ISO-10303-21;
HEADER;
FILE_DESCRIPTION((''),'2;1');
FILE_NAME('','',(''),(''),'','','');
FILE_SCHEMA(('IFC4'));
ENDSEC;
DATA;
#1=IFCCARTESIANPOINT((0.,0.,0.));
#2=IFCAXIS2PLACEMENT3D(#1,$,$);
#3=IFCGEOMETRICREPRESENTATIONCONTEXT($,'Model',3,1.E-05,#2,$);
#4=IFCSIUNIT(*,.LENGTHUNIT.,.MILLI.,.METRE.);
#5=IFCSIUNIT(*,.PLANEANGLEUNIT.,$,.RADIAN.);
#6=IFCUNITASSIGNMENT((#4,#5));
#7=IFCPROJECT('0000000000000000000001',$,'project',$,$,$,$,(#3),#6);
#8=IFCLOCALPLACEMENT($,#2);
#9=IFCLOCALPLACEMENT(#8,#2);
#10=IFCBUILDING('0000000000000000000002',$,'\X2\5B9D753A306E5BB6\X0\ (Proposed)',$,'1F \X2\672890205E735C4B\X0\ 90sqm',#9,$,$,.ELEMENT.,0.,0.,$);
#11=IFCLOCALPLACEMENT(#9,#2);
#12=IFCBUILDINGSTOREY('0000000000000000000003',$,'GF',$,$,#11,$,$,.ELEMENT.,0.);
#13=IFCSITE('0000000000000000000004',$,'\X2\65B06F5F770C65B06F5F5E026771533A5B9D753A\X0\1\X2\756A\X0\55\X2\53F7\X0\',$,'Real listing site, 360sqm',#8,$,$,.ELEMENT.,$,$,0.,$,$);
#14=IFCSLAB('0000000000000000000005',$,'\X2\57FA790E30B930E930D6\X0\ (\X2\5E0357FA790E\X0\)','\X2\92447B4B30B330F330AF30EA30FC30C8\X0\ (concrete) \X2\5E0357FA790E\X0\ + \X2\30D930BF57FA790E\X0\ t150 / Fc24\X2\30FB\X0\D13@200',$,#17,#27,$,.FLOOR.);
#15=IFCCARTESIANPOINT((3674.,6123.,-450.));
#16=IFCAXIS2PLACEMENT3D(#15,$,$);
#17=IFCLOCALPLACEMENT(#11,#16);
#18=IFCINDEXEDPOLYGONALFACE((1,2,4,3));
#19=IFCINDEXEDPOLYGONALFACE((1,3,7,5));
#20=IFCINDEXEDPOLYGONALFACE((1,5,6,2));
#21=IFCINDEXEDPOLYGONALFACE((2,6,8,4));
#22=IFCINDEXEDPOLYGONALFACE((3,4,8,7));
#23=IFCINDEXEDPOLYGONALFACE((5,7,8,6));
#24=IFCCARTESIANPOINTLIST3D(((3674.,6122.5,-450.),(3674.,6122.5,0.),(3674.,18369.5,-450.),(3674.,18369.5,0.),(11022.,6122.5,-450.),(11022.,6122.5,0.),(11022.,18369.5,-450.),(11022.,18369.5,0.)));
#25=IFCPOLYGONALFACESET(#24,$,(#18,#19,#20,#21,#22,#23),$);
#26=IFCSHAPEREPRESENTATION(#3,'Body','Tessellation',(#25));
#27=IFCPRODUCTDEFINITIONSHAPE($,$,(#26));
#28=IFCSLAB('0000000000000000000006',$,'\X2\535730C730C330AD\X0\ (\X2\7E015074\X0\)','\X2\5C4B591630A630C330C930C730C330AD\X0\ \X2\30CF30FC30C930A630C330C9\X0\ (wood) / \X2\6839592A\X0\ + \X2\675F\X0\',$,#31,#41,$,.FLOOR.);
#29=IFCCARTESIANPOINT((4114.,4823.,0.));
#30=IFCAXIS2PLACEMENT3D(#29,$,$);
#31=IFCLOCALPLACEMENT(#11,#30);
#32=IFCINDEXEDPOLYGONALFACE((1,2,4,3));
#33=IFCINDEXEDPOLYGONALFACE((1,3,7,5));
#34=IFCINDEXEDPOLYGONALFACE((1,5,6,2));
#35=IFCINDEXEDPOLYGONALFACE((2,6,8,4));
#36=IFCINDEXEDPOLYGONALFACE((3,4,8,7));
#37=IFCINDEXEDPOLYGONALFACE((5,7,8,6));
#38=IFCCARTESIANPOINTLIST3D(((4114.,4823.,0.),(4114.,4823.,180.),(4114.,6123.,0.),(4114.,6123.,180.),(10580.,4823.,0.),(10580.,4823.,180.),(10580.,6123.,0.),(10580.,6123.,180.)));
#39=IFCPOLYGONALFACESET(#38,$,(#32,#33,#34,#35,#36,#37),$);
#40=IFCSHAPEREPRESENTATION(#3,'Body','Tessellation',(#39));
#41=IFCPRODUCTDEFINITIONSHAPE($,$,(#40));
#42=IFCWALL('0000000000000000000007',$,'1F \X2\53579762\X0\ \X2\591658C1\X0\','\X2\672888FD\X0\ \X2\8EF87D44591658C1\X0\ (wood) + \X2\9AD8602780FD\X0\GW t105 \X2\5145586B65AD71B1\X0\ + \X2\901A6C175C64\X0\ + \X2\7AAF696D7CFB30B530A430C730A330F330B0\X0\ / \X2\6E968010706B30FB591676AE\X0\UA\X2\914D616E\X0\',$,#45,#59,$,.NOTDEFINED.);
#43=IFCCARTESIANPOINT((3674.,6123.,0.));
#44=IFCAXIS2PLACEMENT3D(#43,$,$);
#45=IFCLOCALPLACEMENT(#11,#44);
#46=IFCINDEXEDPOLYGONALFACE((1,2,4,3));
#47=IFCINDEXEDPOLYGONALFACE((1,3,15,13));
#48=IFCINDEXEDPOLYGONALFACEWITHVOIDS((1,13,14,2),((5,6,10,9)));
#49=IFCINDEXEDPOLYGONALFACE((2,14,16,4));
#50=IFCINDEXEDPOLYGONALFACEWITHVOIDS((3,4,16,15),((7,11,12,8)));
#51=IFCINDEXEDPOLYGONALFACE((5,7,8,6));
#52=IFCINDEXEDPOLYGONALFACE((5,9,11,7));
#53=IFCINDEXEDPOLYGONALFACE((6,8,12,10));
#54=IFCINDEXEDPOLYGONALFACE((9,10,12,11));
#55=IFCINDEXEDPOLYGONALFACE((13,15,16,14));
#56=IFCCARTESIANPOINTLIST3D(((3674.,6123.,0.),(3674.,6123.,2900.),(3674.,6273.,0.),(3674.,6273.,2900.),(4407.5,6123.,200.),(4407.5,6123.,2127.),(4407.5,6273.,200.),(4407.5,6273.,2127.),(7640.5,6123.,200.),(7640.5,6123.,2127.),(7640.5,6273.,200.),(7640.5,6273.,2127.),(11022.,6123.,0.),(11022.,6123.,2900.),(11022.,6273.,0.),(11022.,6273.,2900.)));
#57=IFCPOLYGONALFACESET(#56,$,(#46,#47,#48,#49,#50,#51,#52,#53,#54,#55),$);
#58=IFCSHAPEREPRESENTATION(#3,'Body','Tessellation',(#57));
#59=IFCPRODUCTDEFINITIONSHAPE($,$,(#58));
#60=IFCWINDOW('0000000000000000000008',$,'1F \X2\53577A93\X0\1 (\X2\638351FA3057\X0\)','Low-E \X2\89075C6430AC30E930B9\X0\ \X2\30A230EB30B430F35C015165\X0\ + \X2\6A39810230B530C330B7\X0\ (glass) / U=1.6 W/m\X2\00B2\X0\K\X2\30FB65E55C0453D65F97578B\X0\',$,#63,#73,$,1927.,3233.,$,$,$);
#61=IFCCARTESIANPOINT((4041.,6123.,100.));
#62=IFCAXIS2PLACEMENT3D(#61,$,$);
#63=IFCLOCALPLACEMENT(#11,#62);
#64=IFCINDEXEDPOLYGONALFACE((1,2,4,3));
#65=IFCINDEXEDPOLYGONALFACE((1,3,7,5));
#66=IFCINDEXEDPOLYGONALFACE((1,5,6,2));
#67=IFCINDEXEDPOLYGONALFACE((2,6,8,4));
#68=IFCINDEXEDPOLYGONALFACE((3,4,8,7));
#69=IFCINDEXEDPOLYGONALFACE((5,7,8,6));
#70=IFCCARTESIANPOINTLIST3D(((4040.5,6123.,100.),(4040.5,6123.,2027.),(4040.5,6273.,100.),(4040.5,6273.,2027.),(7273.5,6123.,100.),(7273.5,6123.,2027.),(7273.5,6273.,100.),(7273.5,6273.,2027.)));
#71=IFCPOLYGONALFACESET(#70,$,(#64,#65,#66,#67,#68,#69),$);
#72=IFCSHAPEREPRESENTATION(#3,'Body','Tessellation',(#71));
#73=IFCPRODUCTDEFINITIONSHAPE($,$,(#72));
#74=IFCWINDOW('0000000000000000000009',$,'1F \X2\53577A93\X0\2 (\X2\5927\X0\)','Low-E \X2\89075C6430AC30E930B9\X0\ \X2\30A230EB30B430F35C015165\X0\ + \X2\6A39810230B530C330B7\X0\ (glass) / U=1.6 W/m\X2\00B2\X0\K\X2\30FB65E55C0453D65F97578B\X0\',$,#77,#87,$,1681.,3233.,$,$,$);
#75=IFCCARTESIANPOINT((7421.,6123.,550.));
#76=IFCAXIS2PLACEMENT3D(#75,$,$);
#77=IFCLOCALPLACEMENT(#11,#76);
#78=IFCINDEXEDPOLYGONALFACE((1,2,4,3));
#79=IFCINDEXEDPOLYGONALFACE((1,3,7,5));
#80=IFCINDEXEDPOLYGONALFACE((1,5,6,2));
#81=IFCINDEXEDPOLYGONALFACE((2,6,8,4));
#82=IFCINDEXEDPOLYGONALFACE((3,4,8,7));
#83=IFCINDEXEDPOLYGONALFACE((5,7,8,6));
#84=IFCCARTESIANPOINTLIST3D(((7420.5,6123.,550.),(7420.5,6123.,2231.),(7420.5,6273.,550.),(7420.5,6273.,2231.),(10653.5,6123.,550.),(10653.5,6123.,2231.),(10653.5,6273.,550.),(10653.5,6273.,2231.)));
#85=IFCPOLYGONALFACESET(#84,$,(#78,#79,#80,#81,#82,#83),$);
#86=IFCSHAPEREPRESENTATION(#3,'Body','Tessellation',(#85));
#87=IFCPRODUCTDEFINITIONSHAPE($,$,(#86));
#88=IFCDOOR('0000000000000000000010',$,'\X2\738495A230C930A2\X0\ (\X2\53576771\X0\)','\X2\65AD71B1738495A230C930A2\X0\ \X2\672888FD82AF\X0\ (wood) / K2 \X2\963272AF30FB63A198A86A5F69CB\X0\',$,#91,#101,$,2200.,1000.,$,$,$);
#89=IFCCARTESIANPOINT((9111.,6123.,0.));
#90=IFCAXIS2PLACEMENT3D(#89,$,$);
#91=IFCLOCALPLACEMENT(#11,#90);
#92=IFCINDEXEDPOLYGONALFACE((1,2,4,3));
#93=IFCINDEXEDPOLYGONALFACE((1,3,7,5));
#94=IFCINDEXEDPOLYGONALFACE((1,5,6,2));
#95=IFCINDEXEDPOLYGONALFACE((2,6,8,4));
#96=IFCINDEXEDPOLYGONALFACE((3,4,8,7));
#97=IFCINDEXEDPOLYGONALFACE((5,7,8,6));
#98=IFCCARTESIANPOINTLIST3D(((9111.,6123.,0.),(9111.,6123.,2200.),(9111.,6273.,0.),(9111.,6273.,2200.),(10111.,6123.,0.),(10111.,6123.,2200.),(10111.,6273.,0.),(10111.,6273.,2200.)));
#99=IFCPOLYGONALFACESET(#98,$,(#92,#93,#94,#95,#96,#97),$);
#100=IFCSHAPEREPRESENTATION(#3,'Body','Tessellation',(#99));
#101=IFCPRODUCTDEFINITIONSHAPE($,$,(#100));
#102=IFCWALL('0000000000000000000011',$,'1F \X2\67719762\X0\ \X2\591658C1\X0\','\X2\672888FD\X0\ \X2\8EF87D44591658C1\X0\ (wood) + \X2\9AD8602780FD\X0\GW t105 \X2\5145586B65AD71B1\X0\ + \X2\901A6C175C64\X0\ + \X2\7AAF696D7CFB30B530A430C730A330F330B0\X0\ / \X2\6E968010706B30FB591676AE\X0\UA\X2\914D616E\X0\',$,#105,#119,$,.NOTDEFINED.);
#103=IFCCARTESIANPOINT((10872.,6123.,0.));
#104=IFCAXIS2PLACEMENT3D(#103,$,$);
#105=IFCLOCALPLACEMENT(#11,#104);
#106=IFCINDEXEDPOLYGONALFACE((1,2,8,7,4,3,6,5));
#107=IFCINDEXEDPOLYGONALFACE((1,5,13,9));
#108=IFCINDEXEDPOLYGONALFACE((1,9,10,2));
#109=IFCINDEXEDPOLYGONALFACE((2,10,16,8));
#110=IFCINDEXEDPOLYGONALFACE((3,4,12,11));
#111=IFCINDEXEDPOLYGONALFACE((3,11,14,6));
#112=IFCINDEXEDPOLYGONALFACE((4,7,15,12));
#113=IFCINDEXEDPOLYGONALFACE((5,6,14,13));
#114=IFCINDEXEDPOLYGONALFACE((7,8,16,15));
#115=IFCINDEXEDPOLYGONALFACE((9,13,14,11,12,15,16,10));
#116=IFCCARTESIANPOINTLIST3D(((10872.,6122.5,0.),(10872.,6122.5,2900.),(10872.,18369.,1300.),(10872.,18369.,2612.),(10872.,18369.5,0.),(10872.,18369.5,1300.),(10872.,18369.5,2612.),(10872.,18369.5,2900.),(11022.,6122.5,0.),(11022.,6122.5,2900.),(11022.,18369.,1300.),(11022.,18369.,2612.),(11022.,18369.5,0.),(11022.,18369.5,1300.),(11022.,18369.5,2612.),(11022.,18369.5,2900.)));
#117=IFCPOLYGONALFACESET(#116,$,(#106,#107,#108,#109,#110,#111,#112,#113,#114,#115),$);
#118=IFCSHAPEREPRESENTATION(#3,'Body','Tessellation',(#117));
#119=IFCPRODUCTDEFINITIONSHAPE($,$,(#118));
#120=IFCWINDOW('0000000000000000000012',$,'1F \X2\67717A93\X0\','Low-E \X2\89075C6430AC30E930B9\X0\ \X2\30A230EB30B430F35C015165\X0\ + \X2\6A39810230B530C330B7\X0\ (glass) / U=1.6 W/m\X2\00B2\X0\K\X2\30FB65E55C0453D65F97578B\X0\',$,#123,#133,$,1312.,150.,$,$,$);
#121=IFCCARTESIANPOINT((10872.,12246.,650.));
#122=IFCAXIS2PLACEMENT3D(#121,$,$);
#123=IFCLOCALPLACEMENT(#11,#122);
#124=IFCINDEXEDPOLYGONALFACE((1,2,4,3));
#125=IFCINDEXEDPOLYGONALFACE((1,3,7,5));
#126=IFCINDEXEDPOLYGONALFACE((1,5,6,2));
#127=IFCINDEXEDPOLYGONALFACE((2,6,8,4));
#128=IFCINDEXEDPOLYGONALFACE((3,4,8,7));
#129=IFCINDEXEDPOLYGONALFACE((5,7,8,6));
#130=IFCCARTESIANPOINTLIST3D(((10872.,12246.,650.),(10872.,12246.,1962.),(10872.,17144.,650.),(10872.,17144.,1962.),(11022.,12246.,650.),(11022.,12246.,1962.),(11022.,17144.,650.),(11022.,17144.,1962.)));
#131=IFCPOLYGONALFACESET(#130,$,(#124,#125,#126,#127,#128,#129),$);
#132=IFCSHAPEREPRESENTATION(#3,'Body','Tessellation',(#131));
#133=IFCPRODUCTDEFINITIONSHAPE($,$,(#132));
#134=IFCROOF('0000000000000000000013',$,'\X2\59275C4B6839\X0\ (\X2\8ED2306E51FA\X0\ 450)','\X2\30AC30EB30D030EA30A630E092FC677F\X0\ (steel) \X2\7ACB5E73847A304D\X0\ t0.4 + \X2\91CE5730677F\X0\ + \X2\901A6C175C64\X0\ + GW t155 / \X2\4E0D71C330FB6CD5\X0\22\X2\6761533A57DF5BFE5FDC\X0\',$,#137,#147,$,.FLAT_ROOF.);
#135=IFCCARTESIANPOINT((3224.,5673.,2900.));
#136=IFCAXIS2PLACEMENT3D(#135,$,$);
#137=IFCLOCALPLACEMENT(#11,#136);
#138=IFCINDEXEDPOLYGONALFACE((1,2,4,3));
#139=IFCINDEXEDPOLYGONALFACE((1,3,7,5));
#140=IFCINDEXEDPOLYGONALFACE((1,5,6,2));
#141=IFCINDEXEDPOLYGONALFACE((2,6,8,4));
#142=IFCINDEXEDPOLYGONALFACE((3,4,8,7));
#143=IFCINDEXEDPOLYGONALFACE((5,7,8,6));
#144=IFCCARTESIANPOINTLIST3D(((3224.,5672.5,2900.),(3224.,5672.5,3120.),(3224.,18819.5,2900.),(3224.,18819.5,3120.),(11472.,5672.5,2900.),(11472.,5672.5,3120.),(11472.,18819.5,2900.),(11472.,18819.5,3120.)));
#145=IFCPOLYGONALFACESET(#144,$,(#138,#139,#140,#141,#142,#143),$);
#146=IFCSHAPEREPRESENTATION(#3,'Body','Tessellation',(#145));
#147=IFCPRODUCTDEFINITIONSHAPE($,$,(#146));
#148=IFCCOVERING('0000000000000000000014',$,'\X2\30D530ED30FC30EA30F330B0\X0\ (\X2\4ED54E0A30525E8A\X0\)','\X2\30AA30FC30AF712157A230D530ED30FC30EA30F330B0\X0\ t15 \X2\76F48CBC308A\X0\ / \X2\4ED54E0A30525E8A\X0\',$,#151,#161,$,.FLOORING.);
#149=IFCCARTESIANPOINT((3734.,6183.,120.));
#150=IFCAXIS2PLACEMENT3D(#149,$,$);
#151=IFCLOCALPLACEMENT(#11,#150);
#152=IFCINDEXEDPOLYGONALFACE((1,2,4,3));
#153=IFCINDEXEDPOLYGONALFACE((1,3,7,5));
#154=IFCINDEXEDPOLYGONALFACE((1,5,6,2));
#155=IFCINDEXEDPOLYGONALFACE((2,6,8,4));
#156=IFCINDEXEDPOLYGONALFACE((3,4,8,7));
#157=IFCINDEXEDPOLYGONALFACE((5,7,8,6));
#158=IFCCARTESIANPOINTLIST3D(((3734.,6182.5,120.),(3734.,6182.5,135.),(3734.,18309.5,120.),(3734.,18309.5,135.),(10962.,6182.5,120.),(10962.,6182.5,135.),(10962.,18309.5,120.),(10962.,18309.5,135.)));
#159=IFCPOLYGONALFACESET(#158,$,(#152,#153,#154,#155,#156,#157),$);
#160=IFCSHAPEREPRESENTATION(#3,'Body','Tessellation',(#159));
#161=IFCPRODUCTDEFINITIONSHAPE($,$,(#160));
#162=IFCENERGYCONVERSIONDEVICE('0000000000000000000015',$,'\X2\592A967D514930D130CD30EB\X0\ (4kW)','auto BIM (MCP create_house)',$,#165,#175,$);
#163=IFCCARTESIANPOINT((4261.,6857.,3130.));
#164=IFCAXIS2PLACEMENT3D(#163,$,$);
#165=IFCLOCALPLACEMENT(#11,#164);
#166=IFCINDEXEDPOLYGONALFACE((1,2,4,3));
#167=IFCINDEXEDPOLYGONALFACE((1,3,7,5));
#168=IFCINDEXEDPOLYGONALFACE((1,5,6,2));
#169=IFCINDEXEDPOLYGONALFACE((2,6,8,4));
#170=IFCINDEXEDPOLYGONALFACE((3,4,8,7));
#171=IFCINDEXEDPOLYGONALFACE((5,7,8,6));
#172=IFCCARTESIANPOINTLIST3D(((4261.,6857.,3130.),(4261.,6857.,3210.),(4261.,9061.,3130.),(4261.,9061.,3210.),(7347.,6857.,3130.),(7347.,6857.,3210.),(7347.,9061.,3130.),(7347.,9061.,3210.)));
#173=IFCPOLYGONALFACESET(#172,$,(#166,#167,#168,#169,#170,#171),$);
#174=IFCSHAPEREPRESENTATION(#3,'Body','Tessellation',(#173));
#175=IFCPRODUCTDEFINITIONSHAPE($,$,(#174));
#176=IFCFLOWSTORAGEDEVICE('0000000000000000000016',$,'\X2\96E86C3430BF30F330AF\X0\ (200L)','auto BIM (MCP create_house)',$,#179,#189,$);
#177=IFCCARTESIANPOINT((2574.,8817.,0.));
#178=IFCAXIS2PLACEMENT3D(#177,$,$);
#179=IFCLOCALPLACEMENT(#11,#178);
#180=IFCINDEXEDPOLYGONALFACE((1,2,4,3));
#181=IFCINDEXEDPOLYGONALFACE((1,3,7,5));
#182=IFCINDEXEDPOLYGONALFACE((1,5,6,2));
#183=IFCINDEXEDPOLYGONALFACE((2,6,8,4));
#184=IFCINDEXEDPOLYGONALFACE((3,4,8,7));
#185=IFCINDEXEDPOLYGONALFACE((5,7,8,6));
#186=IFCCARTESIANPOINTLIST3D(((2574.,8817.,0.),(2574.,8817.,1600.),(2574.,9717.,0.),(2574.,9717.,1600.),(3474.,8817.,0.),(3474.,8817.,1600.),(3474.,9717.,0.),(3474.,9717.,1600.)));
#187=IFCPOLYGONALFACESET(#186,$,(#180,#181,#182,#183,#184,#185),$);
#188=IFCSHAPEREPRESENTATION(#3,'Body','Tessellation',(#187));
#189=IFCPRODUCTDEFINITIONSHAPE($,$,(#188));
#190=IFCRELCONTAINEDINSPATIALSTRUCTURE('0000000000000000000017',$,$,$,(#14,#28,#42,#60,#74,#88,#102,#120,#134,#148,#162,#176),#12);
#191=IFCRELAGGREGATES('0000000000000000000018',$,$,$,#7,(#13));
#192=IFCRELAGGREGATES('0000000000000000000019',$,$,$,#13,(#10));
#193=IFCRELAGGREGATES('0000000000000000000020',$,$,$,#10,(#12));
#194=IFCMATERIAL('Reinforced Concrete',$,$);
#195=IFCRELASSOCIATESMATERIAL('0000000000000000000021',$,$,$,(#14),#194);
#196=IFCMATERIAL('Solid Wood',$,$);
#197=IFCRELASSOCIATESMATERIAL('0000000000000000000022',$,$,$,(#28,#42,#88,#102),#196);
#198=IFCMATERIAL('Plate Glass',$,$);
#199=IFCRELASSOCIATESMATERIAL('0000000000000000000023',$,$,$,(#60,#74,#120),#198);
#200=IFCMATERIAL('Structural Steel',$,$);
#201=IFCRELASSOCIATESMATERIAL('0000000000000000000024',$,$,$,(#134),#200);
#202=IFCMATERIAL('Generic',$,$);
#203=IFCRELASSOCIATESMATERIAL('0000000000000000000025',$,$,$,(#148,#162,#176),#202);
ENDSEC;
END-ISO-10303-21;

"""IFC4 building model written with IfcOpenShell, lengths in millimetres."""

from ifc_helpers import new_model, si_unit, frame, frame_2d, origin, place, context, project, spatial, rectangle, extrude, material, element, fill, save


model = new_model("IFC4")

# Units and contexts
model_context = context("Model", 3, precision=1e-05, world=origin())
ifc_project = project(units=[si_unit("LENGTHUNIT", "METRE", prefix="MILLI"), si_unit("PLANEANGLEUNIT", "RADIAN")], contexts=[model_context])

# Site, building, storey
site_placement = place(None, origin())
site = spatial("IfcSite", under=ifc_project, at=site_placement, Name="新潟県新潟市東区宝町1番55号", ObjectType="Real listing site, 360sqm", CompositionType="ELEMENT", RefElevation=0.0)
building_placement = place(site_placement, origin())
building = spatial("IfcBuilding", under=site, at=building_placement, Name="宝町の家 (Proposed)", ObjectType="1F 木造平屋 90sqm", CompositionType="ELEMENT", ElevationOfRefHeight=0.0, ElevationOfTerrain=0.0)
storey_placement = place(building_placement, origin())
storey = spatial("IfcBuildingStorey", under=building, at=storey_placement, Name="GF", CompositionType="ELEMENT", Elevation=0.0)

# Slabs
ifc_material_1 = material(Name="Reinforced Concrete")
slab_1_placement = place(storey_placement, frame((3674.0, 6123.0, -450.0)))
element("IfcSlab", 1, at=slab_1_placement, inside=storey, material=ifc_material_1, Name="基礎スラブ (布基礎)", Description="鉄筋コンクリート (concrete) 布基礎 + ベタ基礎 t150 / Fc24・D13@200", PredefinedType="FLOOR", context=model_context, shape_type="SweptSolid", body=[
    extrude(rectangle(XDim=7348.0, YDim=12247.0, at=frame_2d((3674.0, 6123.0))), frame((3674.0, 6123.0, -450.0)), (0.0, 0.0, 1.0), 450.0),
])
ifc_material_2 = material(Name="Solid Wood")
slab_2_placement = place(storey_placement, frame((4114.0, 4823.0, 0.0)))
element("IfcSlab", 2, at=slab_2_placement, inside=storey, material=ifc_material_2, Name="南デッキ (縁側)", Description="屋外ウッドデッキ ハードウッド (wood) / 根太 + 束", PredefinedType="FLOOR", context=model_context, shape_type="SweptSolid", body=[
    extrude(rectangle(XDim=6466.0, YDim=1300.0, at=frame_2d((3233.0, 650.0))), frame((4114.0, 4823.0, 0.0)), (0.0, 0.0, 1.0), 180.0),
])

# Wall, openings, windows, door
wall_1_placement = place(storey_placement, frame((3674.0, 6123.0, 0.0)))
wall_1 = element("IfcWall", 3, at=wall_1_placement, inside=storey, material=ifc_material_2, Name="1F 南面 外壁", Description="木製 軸組外壁 (wood) + 高性能GW t105 充填断熱 + 通気層 + 窯業系サイディング / 準耐火・外皮UA配慮", PredefinedType="NOTDEFINED", context=model_context, shape_type="SweptSolid", body=[
    extrude(rectangle(XDim=7348.0, YDim=150.0, at=frame_2d((3674.0, 75.0))), frame((3674.0, 6123.0, 0.0)), (0.0, 0.0, 1.0), 2900.0),
])
opening_1_placement = place(storey_placement, frame((4041.0, 6123.0, 100.0)))
opening_1 = element("IfcOpeningElement", 4, at=opening_1_placement, cuts=wall_1, PredefinedType="NOTDEFINED", context=model_context, shape_type="SweptSolid", body=[
    extrude(rectangle(XDim=3233.0, YDim=150.0, at=frame_2d((1616.0, 75.0))), frame((4041.0, 6123.0, 100.0)), (0.0, 0.0, 1.0), 1927.0),
])
opening_2_placement = place(storey_placement, frame((7421.0, 6123.0, 550.0)))
opening_2 = element("IfcOpeningElement", 5, at=opening_2_placement, cuts=wall_1, PredefinedType="NOTDEFINED", context=model_context, shape_type="SweptSolid", body=[
    extrude(rectangle(XDim=3233.0, YDim=150.0, at=frame_2d((1616.0, 75.0))), frame((7421.0, 6123.0, 550.0)), (0.0, 0.0, 1.0), 1681.0),
])
opening_3_placement = place(storey_placement, frame((9111.0, 6123.0, 0.0)))
opening_3 = element("IfcOpeningElement", 6, at=opening_3_placement, cuts=wall_1, PredefinedType="NOTDEFINED", context=model_context, shape_type="SweptSolid", body=[
    extrude(rectangle(XDim=1000.0, YDim=150.0, at=frame_2d((500.0, 75.0))), frame((9111.0, 6123.0, 0.0)), (0.0, 0.0, 1.0), 2200.0),
])
ifc_material_3 = material(Name="Plate Glass")
window_1_placement = place(storey_placement, frame((4041.0, 6123.0, 100.0)))
window_1 = element("IfcWindow", 7, at=window_1_placement, inside=storey, material=ifc_material_3, Name="1F 南窓1 (掃出し)", Description="Low-E 複層ガラス アルゴン封入 + 樹脂サッシ (glass) / U=1.6 W/m²K・日射取得型", OverallHeight=1927.0, OverallWidth=3233.0, context=model_context, shape_type="SweptSolid", body=[
    extrude(rectangle(XDim=3233.0, YDim=150.0, at=frame_2d((1616.0, 75.0))), frame((4041.0, 6123.0, 100.0)), (0.0, 0.0, 1.0), 1927.0),
])
fill(opening_1, window_1)
window_2_placement = place(storey_placement, frame((7421.0, 6123.0, 550.0)))
window_2 = element("IfcWindow", 8, at=window_2_placement, inside=storey, material=ifc_material_3, Name="1F 南窓2 (大)", Description="Low-E 複層ガラス アルゴン封入 + 樹脂サッシ (glass) / U=1.6 W/m²K・日射取得型", OverallHeight=1681.0, OverallWidth=3233.0, context=model_context, shape_type="SweptSolid", body=[
    extrude(rectangle(XDim=3233.0, YDim=150.0, at=frame_2d((1616.0, 75.0))), frame((7421.0, 6123.0, 550.0)), (0.0, 0.0, 1.0), 1681.0),
])
fill(opening_2, window_2)
door_placement = place(storey_placement, frame((9111.0, 6123.0, 0.0)))
door = element("IfcDoor", 9, at=door_placement, inside=storey, material=ifc_material_2, Name="玄関ドア (南東)", Description="断熱玄関ドア 木製芯 (wood) / K2 防犯・採風機構", OverallHeight=2200.0, OverallWidth=1000.0, context=model_context, shape_type="SweptSolid", body=[
    extrude(rectangle(XDim=1000.0, YDim=150.0, at=frame_2d((500.0, 75.0))), frame((9111.0, 6123.0, 0.0)), (0.0, 0.0, 1.0), 2200.0),
])
fill(opening_3, door)

# Wall, opening, window
wall_2_placement = place(storey_placement, frame((10872.0, 6123.0, 0.0)))
wall_2 = element("IfcWall", 10, at=wall_2_placement, inside=storey, material=ifc_material_2, Name="1F 東面 外壁", Description="木製 軸組外壁 (wood) + 高性能GW t105 充填断熱 + 通気層 + 窯業系サイディング / 準耐火・外皮UA配慮", PredefinedType="NOTDEFINED", context=model_context, shape_type="SweptSolid", body=[
    extrude(rectangle(XDim=150.0, YDim=12247.0, at=frame_2d((75.0, 6123.0))), frame((10872.0, 6123.0, 0.0)), (0.0, 0.0, 1.0), 2900.0),
])
opening_4_placement = place(storey_placement, frame((10872.0, 12246.0, 650.0)))
opening_4 = element("IfcOpeningElement", 11, at=opening_4_placement, cuts=wall_2, PredefinedType="NOTDEFINED", context=model_context, shape_type="SweptSolid", body=[
    extrude(rectangle(XDim=150.0, YDim=4898.0, at=frame_2d((75.0, 2449.0))), frame((10872.0, 12246.0, 650.0)), (0.0, 0.0, 1.0), 1312.0),
])
window_3_placement = place(storey_placement, frame((10872.0, 12246.0, 650.0)))
window_3 = element("IfcWindow", 12, at=window_3_placement, inside=storey, material=ifc_material_3, Name="1F 東窓", Description="Low-E 複層ガラス アルゴン封入 + 樹脂サッシ (glass) / U=1.6 W/m²K・日射取得型", OverallHeight=1312.0, OverallWidth=150.0, context=model_context, shape_type="SweptSolid", body=[
    extrude(rectangle(XDim=150.0, YDim=4898.0, at=frame_2d((75.0, 2449.0))), frame((10872.0, 12246.0, 650.0)), (0.0, 0.0, 1.0), 1312.0),
])
fill(opening_4, window_3)

# Roof
ifc_material_4 = material(Name="Structural Steel")
roof_placement = place(storey_placement, frame((3224.0, 5673.0, 2900.0)))
element("IfcRoof", 13, at=roof_placement, inside=storey, material=ifc_material_4, Name="大屋根 (軒の出 450)", Description="ガルバリウム鋼板 (steel) 立平葺き t0.4 + 野地板 + 通気層 + GW t155 / 不燃・法22条区域対応", PredefinedType="FLAT_ROOF", context=model_context, shape_type="SweptSolid", body=[
    extrude(rectangle(XDim=8248.0, YDim=13147.0, at=frame_2d((4124.0, 6573.0))), frame((3224.0, 5673.0, 2900.0)), (0.0, 0.0, 1.0), 220.0),
])

# Covering
ifc_material_5 = material(Name="Generic")
covering_placement = place(storey_placement, frame((3734.0, 6183.0, 120.0)))
element("IfcCovering", 14, at=covering_placement, inside=storey, material=ifc_material_5, Name="フローリング (仕上げ床)", Description="オーク無垢フローリング t15 直貼り / 仕上げ床", PredefinedType="FLOORING", context=model_context, shape_type="SweptSolid", body=[
    extrude(rectangle(XDim=7228.0, YDim=12127.0, at=frame_2d((3614.0, 6063.0))), frame((3734.0, 6183.0, 120.0)), (0.0, 0.0, 1.0), 15.0),
])

# Energy conversion device
energy_conversion_device_placement = place(storey_placement, frame((4261.0, 6857.0, 3130.0)))
element("IfcEnergyConversionDevice", 15, at=energy_conversion_device_placement, inside=storey, material=ifc_material_5, Name="太陽光パネル (4kW)", Description="auto BIM (MCP create_house)", context=model_context, shape_type="SweptSolid", body=[
    extrude(rectangle(XDim=3086.0, YDim=2204.0, at=frame_2d((1543.0, 1102.0))), frame((4261.0, 6857.0, 3130.0)), (0.0, 0.0, 1.0), 80.0),
])

# Flow storage device
flow_storage_device_placement = place(storey_placement, frame((2574.0, 8817.0, 0.0)))
element("IfcFlowStorageDevice", 16, at=flow_storage_device_placement, inside=storey, material=ifc_material_5, Name="雨水タンク (200L)", Description="auto BIM (MCP create_house)", context=model_context, shape_type="SweptSolid", body=[
    extrude(rectangle(XDim=900.0, YDim=900.0, at=frame_2d((450.0, 450.0))), frame((2574.0, 8817.0, 0.0)), (0.0, 0.0, 1.0), 1600.0),
])

save(model, "model.ifc")
